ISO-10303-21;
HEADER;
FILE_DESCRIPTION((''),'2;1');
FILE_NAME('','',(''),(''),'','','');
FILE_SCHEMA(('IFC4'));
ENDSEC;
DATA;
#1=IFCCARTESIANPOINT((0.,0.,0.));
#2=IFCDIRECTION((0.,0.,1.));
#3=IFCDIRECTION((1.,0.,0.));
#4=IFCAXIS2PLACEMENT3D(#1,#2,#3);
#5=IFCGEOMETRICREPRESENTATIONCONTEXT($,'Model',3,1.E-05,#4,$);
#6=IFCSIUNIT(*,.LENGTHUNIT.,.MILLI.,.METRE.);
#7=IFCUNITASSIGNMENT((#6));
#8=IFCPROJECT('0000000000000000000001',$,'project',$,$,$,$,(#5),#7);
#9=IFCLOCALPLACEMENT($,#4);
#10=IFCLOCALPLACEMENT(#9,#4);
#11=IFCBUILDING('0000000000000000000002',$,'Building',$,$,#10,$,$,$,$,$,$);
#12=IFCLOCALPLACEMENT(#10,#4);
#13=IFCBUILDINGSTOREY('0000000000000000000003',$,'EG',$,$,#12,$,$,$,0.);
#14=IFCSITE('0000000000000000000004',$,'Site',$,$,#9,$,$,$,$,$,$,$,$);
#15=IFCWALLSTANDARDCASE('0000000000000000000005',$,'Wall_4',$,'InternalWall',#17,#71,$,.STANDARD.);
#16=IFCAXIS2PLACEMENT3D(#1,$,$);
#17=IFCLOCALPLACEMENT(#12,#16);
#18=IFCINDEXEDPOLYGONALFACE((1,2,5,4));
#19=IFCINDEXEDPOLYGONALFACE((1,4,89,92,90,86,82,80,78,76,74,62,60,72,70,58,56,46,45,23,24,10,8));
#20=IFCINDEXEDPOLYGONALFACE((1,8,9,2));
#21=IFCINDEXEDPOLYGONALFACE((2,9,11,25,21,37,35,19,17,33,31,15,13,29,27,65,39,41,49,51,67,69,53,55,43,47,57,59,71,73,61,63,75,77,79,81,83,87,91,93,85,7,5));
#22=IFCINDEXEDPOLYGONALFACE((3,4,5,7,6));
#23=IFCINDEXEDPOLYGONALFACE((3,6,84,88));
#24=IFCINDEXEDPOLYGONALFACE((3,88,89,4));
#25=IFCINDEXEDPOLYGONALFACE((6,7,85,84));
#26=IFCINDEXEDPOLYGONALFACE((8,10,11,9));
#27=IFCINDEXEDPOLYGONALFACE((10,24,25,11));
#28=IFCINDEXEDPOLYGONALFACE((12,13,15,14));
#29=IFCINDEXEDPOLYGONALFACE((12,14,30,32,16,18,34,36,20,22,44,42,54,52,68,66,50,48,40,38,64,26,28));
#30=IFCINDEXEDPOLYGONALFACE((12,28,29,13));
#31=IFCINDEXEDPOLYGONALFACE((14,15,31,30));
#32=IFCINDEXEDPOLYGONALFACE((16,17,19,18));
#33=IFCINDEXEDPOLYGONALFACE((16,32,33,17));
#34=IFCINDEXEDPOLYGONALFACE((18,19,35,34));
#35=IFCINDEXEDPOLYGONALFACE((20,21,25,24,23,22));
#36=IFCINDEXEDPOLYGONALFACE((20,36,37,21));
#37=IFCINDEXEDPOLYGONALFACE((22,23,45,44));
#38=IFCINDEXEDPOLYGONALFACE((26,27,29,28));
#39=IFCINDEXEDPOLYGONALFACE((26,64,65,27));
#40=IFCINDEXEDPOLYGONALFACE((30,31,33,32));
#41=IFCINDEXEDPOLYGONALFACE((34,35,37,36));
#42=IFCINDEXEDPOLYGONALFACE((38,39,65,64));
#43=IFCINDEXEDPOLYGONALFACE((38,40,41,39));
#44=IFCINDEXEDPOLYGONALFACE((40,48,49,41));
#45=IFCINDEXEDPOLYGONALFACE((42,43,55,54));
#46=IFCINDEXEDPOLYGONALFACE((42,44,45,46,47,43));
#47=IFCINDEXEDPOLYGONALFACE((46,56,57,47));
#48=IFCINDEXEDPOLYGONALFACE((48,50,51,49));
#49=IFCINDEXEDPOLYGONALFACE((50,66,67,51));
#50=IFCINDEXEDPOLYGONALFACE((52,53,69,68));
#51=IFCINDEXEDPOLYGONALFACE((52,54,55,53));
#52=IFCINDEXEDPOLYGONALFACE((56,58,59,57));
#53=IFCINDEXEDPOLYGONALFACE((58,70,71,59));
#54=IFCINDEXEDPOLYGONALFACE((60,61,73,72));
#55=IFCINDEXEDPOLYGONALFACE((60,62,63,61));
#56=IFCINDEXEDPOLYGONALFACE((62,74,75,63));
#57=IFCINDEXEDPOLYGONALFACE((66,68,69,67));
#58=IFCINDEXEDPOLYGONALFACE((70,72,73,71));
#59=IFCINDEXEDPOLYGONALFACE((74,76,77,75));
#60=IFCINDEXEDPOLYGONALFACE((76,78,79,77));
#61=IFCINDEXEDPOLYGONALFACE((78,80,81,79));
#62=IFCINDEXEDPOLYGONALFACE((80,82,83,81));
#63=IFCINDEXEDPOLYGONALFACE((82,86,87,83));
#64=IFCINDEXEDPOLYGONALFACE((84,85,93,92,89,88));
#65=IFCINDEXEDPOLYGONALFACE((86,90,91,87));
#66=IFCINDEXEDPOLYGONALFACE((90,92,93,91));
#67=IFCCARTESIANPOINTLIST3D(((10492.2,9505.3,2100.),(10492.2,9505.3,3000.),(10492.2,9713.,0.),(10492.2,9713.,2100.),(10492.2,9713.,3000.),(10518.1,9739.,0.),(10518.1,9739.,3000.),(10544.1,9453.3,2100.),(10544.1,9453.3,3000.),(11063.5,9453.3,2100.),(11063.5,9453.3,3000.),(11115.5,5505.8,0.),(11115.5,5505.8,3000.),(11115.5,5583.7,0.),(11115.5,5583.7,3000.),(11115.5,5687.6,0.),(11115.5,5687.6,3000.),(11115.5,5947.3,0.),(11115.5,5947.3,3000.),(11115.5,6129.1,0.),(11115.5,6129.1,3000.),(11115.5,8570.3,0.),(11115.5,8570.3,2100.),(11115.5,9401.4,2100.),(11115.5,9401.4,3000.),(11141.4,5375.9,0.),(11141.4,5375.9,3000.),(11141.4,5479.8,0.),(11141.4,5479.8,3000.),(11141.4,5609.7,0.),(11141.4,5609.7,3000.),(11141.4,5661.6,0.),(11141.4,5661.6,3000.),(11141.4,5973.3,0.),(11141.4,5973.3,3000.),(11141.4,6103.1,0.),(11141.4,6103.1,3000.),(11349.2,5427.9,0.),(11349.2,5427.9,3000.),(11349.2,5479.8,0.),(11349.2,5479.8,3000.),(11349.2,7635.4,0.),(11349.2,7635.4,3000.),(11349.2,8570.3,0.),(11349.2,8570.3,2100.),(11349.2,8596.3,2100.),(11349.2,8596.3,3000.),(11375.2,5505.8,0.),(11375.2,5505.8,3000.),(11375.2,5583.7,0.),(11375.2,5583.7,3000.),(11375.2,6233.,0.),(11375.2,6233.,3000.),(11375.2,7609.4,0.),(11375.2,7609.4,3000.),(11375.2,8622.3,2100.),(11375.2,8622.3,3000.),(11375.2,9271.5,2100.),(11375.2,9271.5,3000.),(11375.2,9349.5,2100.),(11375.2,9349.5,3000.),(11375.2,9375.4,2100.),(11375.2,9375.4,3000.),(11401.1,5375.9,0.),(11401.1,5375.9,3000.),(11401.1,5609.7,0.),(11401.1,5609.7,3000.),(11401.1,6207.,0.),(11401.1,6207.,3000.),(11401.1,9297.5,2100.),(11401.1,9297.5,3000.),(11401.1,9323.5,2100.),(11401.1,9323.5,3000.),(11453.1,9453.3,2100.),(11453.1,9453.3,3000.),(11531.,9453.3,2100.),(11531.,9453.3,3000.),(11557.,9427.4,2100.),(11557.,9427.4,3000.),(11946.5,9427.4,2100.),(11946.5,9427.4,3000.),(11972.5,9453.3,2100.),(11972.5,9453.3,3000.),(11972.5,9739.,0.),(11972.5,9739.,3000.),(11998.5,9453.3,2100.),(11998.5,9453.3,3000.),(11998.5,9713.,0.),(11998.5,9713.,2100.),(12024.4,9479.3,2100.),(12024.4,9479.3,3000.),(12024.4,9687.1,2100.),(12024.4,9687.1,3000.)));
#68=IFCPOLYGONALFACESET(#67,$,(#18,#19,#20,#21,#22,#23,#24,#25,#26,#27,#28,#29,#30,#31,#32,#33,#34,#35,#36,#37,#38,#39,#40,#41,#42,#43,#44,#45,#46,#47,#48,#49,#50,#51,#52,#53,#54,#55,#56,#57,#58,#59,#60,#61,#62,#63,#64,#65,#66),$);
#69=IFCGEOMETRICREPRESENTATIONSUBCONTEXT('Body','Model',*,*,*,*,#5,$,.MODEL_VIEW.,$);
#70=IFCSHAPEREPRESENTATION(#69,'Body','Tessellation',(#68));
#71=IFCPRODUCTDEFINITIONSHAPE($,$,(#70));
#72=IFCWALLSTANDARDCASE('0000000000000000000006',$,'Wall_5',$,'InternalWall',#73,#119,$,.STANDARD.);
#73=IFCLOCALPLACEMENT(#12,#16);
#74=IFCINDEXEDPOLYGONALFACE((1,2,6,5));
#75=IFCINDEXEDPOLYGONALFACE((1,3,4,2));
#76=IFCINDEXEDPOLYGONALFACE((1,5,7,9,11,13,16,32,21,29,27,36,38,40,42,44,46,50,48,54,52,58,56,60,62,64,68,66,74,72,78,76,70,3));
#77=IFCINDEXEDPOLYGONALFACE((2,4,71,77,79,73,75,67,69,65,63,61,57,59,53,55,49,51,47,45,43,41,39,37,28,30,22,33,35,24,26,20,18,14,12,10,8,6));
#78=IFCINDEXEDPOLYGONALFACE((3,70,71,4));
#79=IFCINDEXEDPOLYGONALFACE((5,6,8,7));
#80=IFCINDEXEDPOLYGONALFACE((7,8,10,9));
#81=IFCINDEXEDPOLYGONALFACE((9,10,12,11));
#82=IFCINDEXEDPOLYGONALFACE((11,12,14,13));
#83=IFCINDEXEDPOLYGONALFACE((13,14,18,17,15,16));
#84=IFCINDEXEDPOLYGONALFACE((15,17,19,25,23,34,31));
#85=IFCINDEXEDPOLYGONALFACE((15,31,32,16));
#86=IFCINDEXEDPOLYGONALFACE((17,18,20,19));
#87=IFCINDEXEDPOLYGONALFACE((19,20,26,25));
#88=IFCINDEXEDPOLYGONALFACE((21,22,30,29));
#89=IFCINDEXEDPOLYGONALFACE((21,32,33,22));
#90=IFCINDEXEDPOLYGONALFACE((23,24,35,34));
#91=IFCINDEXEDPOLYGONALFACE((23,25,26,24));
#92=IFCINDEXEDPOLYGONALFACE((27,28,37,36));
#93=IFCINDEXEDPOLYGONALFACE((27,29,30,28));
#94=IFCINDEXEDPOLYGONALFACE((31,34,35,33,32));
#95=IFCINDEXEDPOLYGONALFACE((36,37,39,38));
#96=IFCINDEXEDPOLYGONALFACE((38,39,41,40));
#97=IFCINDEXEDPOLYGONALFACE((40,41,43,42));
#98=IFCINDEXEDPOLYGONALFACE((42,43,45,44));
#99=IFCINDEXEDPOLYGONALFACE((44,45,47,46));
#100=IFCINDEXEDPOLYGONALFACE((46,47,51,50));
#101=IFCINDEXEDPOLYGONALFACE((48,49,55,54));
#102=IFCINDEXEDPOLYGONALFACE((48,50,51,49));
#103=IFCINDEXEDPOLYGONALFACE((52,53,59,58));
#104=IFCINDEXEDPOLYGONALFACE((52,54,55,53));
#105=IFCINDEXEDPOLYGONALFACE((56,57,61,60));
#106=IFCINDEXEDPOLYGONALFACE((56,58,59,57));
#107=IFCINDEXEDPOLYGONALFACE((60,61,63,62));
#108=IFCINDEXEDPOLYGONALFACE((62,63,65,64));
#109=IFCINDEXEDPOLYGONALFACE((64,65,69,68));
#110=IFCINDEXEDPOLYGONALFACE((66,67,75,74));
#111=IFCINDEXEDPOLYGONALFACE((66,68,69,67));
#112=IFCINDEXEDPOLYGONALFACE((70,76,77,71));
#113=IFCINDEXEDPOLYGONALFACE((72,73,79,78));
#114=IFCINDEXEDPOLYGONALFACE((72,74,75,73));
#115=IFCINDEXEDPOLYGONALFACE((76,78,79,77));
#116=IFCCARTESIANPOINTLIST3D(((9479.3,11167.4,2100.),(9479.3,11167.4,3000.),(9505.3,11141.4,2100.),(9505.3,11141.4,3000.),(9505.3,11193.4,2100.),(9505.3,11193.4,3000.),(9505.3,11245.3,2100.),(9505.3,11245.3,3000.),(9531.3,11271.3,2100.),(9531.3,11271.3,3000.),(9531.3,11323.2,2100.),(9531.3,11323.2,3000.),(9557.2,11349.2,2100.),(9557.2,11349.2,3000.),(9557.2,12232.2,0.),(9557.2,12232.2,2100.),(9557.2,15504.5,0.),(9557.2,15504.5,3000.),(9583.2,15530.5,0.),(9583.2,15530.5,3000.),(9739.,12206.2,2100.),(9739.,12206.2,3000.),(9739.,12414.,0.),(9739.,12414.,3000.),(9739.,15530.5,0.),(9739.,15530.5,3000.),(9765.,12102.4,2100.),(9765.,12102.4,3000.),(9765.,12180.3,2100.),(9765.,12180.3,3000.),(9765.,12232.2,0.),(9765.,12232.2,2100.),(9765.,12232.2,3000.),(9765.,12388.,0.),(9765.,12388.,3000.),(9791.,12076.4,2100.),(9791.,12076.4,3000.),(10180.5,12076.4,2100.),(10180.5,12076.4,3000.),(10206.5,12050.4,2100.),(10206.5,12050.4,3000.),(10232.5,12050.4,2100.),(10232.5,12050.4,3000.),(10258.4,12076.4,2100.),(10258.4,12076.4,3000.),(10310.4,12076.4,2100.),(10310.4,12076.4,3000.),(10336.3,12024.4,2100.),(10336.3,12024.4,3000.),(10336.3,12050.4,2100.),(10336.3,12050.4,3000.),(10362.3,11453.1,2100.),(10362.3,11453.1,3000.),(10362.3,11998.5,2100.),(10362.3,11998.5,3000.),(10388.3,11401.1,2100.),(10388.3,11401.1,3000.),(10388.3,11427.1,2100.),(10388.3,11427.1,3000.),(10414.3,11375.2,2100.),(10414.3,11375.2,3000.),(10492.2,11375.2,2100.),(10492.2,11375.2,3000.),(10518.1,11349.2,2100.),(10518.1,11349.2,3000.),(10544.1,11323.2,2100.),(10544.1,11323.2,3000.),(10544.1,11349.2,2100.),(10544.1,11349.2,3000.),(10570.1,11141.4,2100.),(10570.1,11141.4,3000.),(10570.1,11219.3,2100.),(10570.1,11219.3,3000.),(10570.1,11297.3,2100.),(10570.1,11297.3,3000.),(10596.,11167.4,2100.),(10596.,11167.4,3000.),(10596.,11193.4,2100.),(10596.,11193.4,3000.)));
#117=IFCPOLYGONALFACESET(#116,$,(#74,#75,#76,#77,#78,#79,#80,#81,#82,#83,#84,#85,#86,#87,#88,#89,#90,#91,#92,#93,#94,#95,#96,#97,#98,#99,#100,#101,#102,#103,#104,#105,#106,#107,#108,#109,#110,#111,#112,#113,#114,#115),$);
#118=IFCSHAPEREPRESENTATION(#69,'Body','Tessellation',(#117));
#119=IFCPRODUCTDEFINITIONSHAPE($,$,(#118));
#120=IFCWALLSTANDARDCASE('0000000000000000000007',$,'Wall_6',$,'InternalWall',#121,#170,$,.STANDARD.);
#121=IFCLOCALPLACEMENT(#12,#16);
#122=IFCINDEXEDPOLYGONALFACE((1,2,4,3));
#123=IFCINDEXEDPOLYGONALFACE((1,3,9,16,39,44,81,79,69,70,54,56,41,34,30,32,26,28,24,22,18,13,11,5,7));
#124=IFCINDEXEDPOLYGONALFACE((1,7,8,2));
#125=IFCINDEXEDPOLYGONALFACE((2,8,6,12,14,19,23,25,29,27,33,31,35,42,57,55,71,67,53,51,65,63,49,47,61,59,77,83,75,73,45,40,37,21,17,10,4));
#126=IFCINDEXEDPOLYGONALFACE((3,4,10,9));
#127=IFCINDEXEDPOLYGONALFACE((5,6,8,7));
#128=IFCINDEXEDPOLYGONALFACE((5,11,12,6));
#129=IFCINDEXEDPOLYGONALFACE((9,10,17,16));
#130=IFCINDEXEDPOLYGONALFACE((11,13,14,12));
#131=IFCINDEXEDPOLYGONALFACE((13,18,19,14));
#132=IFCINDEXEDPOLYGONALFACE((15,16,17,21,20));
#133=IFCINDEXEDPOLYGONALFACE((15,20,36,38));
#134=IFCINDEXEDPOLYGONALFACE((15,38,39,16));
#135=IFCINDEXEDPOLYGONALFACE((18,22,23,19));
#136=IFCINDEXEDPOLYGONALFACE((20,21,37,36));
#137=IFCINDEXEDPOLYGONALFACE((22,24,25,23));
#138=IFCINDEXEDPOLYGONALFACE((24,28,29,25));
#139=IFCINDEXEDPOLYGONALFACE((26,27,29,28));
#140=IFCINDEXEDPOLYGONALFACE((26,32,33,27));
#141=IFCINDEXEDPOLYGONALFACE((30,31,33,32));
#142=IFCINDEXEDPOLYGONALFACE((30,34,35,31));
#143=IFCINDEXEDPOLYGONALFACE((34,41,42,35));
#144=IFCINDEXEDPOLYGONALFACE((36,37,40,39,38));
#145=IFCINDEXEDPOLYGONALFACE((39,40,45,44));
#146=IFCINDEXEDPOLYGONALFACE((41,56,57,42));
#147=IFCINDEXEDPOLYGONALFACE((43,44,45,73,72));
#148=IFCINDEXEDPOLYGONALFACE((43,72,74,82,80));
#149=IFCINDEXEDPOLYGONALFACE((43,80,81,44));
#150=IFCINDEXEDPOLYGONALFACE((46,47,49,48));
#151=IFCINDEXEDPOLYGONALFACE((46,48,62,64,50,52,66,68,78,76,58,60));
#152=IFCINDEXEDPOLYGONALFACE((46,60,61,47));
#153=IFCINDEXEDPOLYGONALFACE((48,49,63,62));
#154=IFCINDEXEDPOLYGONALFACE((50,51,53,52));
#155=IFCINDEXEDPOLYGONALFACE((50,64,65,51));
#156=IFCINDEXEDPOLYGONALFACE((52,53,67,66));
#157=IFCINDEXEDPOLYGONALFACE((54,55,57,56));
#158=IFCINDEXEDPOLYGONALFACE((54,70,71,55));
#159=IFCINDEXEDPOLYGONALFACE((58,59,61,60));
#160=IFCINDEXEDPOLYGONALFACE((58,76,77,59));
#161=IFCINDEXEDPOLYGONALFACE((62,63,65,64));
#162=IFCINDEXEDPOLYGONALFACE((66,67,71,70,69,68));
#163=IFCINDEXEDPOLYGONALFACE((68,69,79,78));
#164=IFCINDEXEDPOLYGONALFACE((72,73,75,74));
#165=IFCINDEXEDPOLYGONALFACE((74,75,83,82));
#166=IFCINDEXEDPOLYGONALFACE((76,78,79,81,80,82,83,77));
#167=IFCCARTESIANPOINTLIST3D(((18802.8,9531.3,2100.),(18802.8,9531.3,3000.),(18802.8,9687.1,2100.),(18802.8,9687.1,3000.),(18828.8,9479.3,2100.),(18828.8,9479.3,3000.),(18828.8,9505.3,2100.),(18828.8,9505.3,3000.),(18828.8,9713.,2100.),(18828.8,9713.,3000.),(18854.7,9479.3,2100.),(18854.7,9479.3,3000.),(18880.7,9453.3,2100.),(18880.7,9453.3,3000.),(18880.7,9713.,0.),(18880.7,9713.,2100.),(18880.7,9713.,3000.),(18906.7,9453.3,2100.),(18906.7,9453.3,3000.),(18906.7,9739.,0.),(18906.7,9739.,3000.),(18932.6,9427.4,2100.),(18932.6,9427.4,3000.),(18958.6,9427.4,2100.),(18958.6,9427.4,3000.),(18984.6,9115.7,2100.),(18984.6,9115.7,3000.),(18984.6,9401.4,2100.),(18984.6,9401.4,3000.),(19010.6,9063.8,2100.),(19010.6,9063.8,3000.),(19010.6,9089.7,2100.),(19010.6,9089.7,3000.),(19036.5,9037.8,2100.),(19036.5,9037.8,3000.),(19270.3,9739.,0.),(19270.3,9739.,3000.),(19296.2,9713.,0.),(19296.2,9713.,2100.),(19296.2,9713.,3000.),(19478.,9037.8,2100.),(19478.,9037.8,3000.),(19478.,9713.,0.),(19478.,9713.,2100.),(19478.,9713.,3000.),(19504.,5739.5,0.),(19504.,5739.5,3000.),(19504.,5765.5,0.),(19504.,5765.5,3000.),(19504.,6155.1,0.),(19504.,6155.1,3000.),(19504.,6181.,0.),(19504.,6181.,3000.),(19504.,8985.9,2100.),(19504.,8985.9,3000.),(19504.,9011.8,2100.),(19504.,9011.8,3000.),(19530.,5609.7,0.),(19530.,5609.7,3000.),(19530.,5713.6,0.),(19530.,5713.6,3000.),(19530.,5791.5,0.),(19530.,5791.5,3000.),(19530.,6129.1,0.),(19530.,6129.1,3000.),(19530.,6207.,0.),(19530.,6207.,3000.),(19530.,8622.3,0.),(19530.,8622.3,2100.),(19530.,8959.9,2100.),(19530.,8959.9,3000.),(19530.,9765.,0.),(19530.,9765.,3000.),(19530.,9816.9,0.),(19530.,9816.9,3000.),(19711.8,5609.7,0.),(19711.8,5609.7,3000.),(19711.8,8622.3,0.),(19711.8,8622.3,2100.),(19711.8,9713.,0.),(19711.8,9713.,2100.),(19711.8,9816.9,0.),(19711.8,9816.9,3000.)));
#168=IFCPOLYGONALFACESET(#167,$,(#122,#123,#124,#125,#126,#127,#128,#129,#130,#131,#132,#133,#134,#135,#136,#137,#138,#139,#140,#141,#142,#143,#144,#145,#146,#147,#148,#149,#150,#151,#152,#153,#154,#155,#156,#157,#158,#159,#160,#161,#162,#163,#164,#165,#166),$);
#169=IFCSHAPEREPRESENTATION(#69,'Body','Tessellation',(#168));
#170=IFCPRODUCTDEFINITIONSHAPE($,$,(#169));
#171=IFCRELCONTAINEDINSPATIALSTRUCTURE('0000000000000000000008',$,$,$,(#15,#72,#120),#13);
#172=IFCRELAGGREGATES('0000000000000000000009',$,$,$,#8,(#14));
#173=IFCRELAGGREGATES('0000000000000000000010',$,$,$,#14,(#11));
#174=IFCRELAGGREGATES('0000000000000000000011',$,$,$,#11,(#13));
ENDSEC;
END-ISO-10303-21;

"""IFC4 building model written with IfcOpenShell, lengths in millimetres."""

from ifc_helpers import new_model, si_unit, frame, origin_with_axes, place, context, subcontext, project, spatial, polyline, rectangle, outline, extrude, element, save


model = new_model("IFC4")

# Units and contexts
model_context = context("Model", 3, precision=1e-05, world=origin_with_axes())
body_context = subcontext(model_context, "Body", "Model", "MODEL_VIEW")
ifc_project = project(units=[si_unit("LENGTHUNIT", "METRE", prefix="MILLI")], contexts=[model_context])

# Site, building, storey
site_placement = place(None, origin_with_axes())
site = spatial("IfcSite", under=ifc_project, at=site_placement, Name="Site")
building_placement = place(site_placement, origin_with_axes())
building = spatial("IfcBuilding", under=site, at=building_placement, Name="Building")
storey_placement = place(building_placement, origin_with_axes())
storey = spatial("IfcBuildingStorey", under=building, at=storey_placement, Name="EG", Elevation=0.0)

# Walls, openings
wall_1_placement = place(storey_placement, origin_with_axes())
wall_1 = element("IfcWallStandardCase", 1, at=wall_1_placement, inside=storey, Name="Wall_4", ObjectType="InternalWall", PredefinedType="STANDARD", context=body_context, shape_type="SweptSolid", body=[
    extrude(outline(polyline([(11141.4, 5375.9, 0.0), (11141.4, 5479.8, 0.0), (11115.5, 5505.8, 0.0), (11115.5, 5583.7, 0.0), (11141.4, 5609.7, 0.0), (11141.4, 5661.6, 0.0), (11115.5, 5687.6, 0.0), (11115.5, 5947.3, 0.0), (11141.4, 5973.3, 0.0), (11141.4, 6103.1, 0.0), (11115.5, 6129.1, 0.0), (11115.5, 9401.4, 0.0), (11063.5, 9453.3, 0.0), (10544.1, 9453.3, 0.0), (10492.2, 9505.3, 0.0), (10492.2, 9713.0, 0.0), (10518.1, 9739.0, 0.0), (11972.5, 9739.0, 0.0), (12024.4, 9687.1, 0.0), (12024.4, 9479.3, 0.0), (11998.5, 9453.3, 0.0), (11972.5, 9453.3, 0.0), (11946.5, 9427.4, 0.0), (11557.0, 9427.4, 0.0), (11531.0, 9453.3, 0.0), (11453.1, 9453.3, 0.0), (11375.2, 9375.4, 0.0), (11375.2, 9349.5, 0.0), (11401.1, 9323.5, 0.0), (11401.1, 9297.5, 0.0), (11375.2, 9271.5, 0.0), (11375.2, 8622.3, 0.0), (11349.2, 8596.3, 0.0), (11349.2, 7635.4, 0.0), (11375.2, 7609.4, 0.0), (11375.2, 6233.0, 0.0), (11401.1, 6207.0, 0.0), (11401.1, 5609.7, 0.0), (11375.2, 5583.7, 0.0), (11375.2, 5505.8, 0.0), (11349.2, 5479.8, 0.0), (11349.2, 5427.9, 0.0), (11401.1, 5375.9, 0.0), (11531.0, 5375.9, 0.0), (11141.4, 5375.9, 0.0)])), origin_with_axes(), (0.0, 0.0, 1.0), 3000.0),
])
opening_1_placement = place(wall_1_placement, origin_with_axes())
element("IfcOpeningElement", 2, at=opening_1_placement, inside=storey, cuts=wall_1, context=body_context, shape_type="SweptSolid", body=[
    extrude(rectangle(XDim=1142.7, YDim=1532.3), frame((11258.3, 9141.7, 0.0), z_axis=(0.0, 0.0, 1.0), x_axis=(0.0, 1.0, 0.0)), (0.0, 0.0, 1.0), 2100.0),
])
wall_2_placement = place(storey_placement, origin_with_axes())
wall_2 = element("IfcWallStandardCase", 3, at=wall_2_placement, inside=storey, Name="Wall_5", ObjectType="InternalWall", PredefinedType="STANDARD", context=body_context, shape_type="SweptSolid", body=[
    extrude(outline(polyline([(9505.3, 11141.4, 0.0), (9479.3, 11167.4, 0.0), (9505.3, 11193.4, 0.0), (9505.3, 11245.3, 0.0), (9531.3, 11271.3, 0.0), (9531.3, 11323.2, 0.0), (9557.2, 11349.2, 0.0), (9557.2, 15504.5, 0.0), (9583.2, 15530.5, 0.0), (9739.0, 15530.5, 0.0), (9739.0, 12414.0, 0.0), (9765.0, 12388.0, 0.0), (9765.0, 12232.2, 0.0), (9739.0, 12206.2, 0.0), (9765.0, 12180.3, 0.0), (9765.0, 12102.4, 0.0), (9791.0, 12076.4, 0.0), (10180.5, 12076.4, 0.0), (10206.5, 12050.4, 0.0), (10232.5, 12050.4, 0.0), (10258.4, 12076.4, 0.0), (10310.4, 12076.4, 0.0), (10336.3, 12050.4, 0.0), (10336.3, 12024.4, 0.0), (10362.3, 11998.5, 0.0), (10362.3, 11453.1, 0.0), (10388.3, 11427.1, 0.0), (10388.3, 11401.1, 0.0), (10414.3, 11375.2, 0.0), (10492.2, 11375.2, 0.0), (10518.1, 11349.2, 0.0), (10544.1, 11349.2, 0.0), (10544.1, 11323.2, 0.0), (10570.1, 11297.3, 0.0), (10570.1, 11219.3, 0.0), (10596.0, 11193.4, 0.0), (10596.0, 11167.4, 0.0), (10570.1, 11141.4, 0.0), (9505.3, 11141.4, 0.0)])), origin_with_axes(), (0.0, 0.0, 1.0), 3000.0),
])
opening_2_placement = place(wall_2_placement, origin_with_axes())
element("IfcOpeningElement", 4, at=opening_2_placement, inside=storey, cuts=wall_2, context=body_context, shape_type="SweptSolid", body=[
    extrude(rectangle(XDim=1090.8, YDim=1116.7), frame((10037.7, 11686.8, 0.0), z_axis=(0.0, 0.0, 1.0), x_axis=(0.0, -1.0, 0.0)), (0.0, 0.0, 1.0), 2100.0),
])
wall_3_placement = place(storey_placement, origin_with_axes())
wall_3 = element("IfcWallStandardCase", 5, at=wall_3_placement, inside=storey, Name="Wall_6", ObjectType="InternalWall", PredefinedType="STANDARD", context=body_context, shape_type="SweptSolid", body=[
    extrude(outline(polyline([(19530.0, 5609.7, 0.0), (19530.0, 5713.6, 0.0), (19504.0, 5739.5, 0.0), (19504.0, 5765.5, 0.0), (19530.0, 5791.5, 0.0), (19530.0, 6129.1, 0.0), (19504.0, 6155.1, 0.0), (19504.0, 6181.0, 0.0), (19530.0, 6207.0, 0.0), (19530.0, 8959.9, 0.0), (19504.0, 8985.9, 0.0), (19504.0, 9011.8, 0.0), (19478.0, 9037.8, 0.0), (19036.5, 9037.8, 0.0), (19010.6, 9063.8, 0.0), (19010.6, 9089.7, 0.0), (18984.6, 9115.7, 0.0), (18984.6, 9401.4, 0.0), (18958.6, 9427.4, 0.0), (18932.6, 9427.4, 0.0), (18906.7, 9453.3, 0.0), (18880.7, 9453.3, 0.0), (18854.7, 9479.3, 0.0), (18828.8, 9479.3, 0.0), (18828.8, 9505.3, 0.0), (18802.8, 9531.3, 0.0), (18802.8, 9687.1, 0.0), (18828.8, 9713.0, 0.0), (18880.7, 9713.0, 0.0), (18906.7, 9739.0, 0.0), (19270.3, 9739.0, 0.0), (19296.2, 9713.0, 0.0), (19478.0, 9713.0, 0.0), (19530.0, 9765.0, 0.0), (19530.0, 9816.9, 0.0), (19711.8, 9816.9, 0.0), (19711.8, 5609.7, 0.0), (19530.0, 5609.7, 0.0)])), origin_with_axes(), (0.0, 0.0, 1.0), 3000.0),
])
opening_3_placement = place(wall_3_placement, origin_with_axes())
element("IfcOpeningElement", 6, at=opening_3_placement, inside=storey, cuts=wall_3, context=body_context, shape_type="SweptSolid", body=[
    extrude(rectangle(XDim=1090.8, YDim=909.0), frame((19257.3, 9167.7, 0.0), z_axis=(0.0, 0.0, 1.0), x_axis=(0.0, -1.0, 0.0)), (0.0, 0.0, 1.0), 2100.0),
])

save(model, "model.ifc")
